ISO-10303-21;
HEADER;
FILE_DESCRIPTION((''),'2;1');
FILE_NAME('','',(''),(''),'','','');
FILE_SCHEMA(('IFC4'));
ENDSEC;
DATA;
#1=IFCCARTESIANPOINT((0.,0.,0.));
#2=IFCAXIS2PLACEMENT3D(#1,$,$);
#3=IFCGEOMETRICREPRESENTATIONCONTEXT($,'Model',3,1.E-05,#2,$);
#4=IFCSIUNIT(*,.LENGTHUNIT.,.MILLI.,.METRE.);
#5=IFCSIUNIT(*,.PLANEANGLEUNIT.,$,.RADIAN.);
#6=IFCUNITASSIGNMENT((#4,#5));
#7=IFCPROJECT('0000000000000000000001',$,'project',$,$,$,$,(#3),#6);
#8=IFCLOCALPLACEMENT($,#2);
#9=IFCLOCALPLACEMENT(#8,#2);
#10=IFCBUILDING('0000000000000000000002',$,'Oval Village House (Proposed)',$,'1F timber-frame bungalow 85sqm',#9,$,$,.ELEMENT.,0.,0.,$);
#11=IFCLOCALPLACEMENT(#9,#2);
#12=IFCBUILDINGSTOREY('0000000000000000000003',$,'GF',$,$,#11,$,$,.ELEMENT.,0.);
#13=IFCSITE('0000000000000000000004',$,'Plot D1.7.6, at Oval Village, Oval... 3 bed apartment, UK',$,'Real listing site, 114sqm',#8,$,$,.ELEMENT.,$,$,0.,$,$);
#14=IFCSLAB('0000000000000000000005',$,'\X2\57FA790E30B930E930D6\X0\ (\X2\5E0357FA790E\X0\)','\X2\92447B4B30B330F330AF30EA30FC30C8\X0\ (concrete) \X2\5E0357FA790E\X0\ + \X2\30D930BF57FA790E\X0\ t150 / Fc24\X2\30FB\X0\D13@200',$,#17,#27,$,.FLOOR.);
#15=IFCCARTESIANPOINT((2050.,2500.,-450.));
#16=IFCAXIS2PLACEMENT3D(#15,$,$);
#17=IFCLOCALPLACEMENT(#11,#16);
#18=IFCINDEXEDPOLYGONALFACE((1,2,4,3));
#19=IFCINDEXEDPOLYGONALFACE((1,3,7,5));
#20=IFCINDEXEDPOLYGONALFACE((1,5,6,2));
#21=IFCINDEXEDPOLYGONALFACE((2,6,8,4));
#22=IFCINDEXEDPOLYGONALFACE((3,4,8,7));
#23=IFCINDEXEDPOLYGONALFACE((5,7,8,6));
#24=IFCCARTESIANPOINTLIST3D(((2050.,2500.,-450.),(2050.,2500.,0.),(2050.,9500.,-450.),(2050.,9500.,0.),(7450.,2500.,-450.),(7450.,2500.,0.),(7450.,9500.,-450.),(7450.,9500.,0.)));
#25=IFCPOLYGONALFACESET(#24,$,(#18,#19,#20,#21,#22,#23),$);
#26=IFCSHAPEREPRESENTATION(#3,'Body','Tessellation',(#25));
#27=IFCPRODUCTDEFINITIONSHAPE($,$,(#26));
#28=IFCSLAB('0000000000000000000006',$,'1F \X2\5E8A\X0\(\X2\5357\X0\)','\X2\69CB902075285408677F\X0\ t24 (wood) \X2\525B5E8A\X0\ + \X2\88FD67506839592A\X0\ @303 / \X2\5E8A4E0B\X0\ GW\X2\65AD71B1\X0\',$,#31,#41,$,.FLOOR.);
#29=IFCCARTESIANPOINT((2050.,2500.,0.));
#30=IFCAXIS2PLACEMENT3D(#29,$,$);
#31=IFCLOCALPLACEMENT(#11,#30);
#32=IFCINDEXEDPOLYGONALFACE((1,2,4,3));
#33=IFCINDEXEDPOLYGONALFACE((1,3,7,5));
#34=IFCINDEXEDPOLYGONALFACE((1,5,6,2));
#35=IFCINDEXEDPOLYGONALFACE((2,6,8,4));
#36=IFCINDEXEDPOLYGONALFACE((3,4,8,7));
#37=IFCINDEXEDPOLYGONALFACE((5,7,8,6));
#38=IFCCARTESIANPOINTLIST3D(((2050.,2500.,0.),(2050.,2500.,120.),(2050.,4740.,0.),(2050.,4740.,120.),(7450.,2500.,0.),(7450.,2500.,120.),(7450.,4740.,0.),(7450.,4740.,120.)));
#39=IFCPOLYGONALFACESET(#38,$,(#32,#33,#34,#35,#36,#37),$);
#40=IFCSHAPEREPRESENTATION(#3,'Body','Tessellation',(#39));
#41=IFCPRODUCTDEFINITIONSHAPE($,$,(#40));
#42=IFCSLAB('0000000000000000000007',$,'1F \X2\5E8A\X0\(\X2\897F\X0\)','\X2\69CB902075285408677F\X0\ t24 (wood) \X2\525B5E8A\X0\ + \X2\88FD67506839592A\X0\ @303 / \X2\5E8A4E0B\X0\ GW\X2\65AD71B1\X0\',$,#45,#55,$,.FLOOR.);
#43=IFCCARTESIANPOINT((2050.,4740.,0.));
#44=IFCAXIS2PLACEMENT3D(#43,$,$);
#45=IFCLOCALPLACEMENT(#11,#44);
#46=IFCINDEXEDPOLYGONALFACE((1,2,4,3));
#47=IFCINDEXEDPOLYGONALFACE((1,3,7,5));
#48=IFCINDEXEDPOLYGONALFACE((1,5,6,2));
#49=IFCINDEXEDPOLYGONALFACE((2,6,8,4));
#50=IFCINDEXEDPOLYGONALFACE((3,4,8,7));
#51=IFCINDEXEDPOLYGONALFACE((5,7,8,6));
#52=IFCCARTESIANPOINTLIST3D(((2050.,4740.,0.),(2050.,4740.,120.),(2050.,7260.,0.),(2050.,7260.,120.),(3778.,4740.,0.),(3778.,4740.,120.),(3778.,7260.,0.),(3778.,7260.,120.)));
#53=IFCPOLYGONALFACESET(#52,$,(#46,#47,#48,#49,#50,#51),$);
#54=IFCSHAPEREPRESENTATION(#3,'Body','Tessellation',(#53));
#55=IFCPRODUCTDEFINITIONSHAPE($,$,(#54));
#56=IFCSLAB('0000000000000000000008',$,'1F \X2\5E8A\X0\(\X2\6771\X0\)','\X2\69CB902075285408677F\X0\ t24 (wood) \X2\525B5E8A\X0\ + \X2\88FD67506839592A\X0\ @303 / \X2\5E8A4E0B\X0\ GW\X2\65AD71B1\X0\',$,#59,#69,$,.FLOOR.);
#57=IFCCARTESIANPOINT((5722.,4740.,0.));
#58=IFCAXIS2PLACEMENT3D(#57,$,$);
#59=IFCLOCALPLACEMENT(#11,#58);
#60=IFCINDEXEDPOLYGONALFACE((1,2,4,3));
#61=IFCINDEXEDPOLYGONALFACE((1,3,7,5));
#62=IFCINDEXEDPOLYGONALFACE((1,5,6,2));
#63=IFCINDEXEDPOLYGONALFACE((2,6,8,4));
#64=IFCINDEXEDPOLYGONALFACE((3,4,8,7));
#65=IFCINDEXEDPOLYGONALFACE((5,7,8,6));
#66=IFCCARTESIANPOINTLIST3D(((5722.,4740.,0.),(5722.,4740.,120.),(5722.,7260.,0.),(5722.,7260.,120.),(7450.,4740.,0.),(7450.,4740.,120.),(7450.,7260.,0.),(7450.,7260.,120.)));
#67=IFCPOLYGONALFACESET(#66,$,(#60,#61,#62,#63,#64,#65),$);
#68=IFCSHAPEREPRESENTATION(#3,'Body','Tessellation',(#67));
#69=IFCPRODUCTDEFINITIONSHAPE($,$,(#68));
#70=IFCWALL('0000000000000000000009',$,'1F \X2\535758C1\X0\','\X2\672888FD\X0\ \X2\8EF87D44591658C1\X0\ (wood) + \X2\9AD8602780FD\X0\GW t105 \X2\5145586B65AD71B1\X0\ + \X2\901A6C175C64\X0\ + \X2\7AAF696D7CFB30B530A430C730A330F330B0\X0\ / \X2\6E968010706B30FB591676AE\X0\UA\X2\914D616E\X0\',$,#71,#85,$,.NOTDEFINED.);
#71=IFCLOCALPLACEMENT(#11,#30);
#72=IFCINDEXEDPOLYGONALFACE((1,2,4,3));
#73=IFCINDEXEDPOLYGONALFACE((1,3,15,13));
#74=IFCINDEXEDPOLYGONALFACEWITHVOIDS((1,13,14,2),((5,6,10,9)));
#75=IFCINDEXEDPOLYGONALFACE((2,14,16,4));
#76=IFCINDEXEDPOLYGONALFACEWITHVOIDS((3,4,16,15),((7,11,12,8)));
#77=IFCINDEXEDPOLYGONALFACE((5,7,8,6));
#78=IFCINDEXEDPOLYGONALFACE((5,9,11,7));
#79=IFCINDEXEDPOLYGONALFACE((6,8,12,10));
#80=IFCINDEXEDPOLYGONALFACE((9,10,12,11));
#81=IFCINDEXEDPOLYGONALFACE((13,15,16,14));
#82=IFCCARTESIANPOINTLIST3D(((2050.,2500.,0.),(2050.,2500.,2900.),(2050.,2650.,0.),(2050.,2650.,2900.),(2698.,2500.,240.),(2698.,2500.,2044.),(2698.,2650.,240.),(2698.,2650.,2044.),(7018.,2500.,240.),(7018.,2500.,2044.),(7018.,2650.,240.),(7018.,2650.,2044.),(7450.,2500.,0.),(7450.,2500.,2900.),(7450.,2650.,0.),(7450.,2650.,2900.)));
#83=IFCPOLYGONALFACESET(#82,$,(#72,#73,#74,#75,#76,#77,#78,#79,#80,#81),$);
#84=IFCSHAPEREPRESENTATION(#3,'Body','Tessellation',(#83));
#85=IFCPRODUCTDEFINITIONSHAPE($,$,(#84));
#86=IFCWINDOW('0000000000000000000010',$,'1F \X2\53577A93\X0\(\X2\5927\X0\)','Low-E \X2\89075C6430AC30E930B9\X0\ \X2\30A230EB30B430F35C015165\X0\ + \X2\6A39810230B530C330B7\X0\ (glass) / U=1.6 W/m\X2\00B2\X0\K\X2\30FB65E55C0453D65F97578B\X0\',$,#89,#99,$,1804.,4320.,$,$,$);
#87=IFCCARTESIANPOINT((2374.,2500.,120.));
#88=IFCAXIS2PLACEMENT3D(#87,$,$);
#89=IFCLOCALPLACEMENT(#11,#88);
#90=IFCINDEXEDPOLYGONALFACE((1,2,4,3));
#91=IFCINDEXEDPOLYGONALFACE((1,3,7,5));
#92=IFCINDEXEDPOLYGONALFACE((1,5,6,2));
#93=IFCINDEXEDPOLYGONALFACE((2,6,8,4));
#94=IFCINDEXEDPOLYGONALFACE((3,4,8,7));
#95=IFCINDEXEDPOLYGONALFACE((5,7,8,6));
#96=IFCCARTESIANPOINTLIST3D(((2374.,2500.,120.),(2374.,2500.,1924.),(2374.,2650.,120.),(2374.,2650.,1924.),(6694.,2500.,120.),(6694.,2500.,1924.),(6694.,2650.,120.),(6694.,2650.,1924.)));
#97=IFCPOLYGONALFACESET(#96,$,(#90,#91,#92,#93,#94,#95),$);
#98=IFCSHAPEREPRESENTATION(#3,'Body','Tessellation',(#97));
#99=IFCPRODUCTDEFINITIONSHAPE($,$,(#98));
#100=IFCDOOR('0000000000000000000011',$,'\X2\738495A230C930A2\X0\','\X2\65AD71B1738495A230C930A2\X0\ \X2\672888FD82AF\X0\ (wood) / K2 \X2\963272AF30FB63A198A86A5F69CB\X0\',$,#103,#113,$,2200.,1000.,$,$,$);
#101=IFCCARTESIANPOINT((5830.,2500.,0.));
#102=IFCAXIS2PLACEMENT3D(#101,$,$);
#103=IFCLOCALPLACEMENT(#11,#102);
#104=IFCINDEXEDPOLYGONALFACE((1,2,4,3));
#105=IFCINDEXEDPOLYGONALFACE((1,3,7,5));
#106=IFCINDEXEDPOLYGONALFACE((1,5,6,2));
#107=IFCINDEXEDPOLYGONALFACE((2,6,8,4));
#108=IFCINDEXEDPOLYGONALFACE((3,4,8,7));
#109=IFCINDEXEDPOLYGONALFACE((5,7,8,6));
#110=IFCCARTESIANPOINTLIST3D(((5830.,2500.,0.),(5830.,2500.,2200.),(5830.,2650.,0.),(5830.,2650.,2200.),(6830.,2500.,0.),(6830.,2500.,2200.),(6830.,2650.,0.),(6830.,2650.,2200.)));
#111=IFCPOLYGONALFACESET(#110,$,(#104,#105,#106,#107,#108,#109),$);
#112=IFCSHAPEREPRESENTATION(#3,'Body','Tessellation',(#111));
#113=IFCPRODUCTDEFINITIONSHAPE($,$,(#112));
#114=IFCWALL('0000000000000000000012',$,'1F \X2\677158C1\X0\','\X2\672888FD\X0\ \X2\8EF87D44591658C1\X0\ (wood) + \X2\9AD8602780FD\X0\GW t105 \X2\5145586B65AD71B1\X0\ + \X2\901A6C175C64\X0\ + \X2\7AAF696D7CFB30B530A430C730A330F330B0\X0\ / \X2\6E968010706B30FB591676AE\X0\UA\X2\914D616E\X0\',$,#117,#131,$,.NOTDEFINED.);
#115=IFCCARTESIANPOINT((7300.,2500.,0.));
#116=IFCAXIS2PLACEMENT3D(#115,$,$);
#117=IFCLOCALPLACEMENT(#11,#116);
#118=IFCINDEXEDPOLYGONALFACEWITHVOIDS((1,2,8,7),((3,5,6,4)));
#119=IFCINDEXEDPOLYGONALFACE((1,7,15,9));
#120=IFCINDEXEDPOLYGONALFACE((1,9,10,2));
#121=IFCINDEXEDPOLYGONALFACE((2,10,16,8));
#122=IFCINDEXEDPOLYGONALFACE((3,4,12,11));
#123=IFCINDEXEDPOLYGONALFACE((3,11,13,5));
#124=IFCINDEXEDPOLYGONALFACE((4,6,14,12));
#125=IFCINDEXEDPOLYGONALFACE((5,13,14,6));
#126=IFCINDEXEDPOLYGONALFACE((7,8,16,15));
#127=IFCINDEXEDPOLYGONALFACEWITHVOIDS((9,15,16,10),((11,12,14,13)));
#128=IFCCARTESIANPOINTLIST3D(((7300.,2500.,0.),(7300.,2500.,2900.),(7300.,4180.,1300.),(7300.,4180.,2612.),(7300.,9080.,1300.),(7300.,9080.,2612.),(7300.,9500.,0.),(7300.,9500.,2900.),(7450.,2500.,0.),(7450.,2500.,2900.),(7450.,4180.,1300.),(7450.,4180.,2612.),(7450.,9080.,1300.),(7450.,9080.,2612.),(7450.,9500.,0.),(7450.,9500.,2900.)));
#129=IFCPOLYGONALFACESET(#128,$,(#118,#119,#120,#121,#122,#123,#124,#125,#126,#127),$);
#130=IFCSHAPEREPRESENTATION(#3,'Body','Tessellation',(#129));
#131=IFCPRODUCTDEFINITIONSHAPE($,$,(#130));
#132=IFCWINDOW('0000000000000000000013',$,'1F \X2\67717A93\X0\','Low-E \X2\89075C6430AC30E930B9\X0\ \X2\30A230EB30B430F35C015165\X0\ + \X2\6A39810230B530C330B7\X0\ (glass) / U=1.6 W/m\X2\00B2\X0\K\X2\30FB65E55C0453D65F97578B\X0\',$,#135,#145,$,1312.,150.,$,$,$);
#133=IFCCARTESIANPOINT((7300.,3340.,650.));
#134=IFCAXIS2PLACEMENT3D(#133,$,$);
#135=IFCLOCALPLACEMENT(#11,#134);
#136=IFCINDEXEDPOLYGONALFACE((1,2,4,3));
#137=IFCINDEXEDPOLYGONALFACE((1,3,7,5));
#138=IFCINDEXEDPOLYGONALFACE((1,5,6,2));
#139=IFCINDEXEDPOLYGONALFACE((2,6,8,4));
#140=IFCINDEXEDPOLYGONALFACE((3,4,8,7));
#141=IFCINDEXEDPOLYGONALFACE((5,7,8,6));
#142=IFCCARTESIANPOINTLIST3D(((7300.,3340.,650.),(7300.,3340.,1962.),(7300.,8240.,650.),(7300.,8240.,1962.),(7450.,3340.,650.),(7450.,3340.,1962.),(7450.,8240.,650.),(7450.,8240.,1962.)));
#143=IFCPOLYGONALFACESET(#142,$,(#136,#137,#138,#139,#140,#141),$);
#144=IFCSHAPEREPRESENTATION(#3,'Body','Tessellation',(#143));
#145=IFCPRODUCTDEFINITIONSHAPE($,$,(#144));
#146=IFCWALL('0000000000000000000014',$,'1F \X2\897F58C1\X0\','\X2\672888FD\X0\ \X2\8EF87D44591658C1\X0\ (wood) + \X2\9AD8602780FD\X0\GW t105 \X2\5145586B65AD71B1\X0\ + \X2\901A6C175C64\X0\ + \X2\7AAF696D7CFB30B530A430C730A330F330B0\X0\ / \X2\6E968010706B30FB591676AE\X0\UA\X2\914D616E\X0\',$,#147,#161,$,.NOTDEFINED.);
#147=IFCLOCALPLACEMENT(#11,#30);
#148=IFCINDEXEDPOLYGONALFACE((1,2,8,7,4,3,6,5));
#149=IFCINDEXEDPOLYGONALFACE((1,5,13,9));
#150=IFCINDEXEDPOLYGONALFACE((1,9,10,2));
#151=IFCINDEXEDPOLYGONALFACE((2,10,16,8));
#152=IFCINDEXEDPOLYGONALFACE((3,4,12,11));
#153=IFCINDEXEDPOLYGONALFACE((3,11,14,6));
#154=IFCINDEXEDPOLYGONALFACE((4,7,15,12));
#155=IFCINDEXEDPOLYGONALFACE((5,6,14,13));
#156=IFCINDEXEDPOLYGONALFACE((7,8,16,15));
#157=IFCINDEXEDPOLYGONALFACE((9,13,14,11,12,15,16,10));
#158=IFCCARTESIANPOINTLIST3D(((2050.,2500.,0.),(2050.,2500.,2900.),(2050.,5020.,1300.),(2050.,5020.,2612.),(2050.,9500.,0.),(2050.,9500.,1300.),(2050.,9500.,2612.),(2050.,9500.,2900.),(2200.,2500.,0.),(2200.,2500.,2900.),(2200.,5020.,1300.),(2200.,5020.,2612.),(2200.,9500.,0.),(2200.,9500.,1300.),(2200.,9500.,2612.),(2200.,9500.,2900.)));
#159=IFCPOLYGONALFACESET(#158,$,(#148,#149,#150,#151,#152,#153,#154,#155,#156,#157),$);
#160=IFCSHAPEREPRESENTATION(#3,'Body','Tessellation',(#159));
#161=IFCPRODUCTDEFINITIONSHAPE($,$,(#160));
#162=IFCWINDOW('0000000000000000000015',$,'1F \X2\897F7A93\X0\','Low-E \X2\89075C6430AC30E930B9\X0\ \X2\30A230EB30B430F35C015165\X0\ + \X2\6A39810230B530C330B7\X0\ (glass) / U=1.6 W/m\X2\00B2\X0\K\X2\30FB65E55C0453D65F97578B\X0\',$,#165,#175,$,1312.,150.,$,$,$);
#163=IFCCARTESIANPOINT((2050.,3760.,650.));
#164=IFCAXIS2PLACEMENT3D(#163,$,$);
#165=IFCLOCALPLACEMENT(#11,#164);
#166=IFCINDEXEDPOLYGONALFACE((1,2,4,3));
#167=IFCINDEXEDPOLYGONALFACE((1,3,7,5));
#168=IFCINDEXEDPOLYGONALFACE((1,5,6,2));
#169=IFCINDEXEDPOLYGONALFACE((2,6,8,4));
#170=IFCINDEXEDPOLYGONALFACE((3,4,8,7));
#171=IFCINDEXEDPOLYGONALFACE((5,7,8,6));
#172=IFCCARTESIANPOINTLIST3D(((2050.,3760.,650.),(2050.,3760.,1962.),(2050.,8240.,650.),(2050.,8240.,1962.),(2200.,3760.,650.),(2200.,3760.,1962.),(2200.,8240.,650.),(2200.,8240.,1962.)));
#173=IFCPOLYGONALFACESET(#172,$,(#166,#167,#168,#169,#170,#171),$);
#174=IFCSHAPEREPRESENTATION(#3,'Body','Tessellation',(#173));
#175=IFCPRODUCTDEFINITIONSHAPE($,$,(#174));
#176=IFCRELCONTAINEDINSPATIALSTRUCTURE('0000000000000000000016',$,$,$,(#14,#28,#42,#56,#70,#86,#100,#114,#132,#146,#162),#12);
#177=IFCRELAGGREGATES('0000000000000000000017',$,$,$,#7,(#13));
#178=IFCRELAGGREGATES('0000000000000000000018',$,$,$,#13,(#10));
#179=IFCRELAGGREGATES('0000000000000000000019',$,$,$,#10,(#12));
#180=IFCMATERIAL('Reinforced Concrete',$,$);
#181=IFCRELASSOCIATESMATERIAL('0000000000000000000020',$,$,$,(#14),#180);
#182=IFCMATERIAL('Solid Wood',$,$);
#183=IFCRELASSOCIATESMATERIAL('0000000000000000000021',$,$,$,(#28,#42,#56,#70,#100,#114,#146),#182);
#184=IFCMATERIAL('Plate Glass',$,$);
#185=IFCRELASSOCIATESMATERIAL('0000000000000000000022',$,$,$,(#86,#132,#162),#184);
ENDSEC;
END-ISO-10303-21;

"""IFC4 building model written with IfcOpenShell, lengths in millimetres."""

from ifc_helpers import new_model, si_unit, frame, frame_2d, origin, place, context, project, spatial, rectangle, extrude, material, element, fill, save


model = new_model("IFC4")

# Units and contexts
model_context = context("Model", 3, precision=1e-05, world=origin())
ifc_project = project(units=[si_unit("LENGTHUNIT", "METRE", prefix="MILLI"), si_unit("PLANEANGLEUNIT", "RADIAN")], contexts=[model_context])

# Site, building, storey
site_placement = place(None, origin())
site = spatial("IfcSite", under=ifc_project, at=site_placement, Name="Plot D1.7.6, at Oval Village, Oval... 3 bed apartment, UK", ObjectType="Real listing site, 114sqm", CompositionType="ELEMENT", RefElevation=0.0)
building_placement = place(site_placement, origin())
building = spatial("IfcBuilding", under=site, at=building_placement, Name="Oval Village House (Proposed)", ObjectType="1F timber-frame bungalow 85sqm", CompositionType="ELEMENT", ElevationOfRefHeight=0.0, ElevationOfTerrain=0.0)
storey_placement = place(building_placement, origin())
storey = spatial("IfcBuildingStorey", under=building, at=storey_placement, Name="GF", CompositionType="ELEMENT", Elevation=0.0)

# Slabs
ifc_material_1 = material(Name="Reinforced Concrete")
slab_1_placement = place(storey_placement, frame((2050.0, 2500.0, -450.0)))
element("IfcSlab", 1, at=slab_1_placement, inside=storey, material=ifc_material_1, Name="基礎スラブ (布基礎)", Description="鉄筋コンクリート (concrete) 布基礎 + ベタ基礎 t150 / Fc24・D13@200", PredefinedType="FLOOR", context=model_context, shape_type="SweptSolid", body=[
    extrude(rectangle(XDim=5400.0, YDim=7000.0, at=frame_2d((2700.0, 3500.0))), frame((2050.0, 2500.0, -450.0)), (0.0, 0.0, 1.0), 450.0),
])
ifc_material_2 = material(Name="Solid Wood")
slab_2_placement = place(storey_placement, frame((2050.0, 2500.0, 0.0)))
element("IfcSlab", 2, at=slab_2_placement, inside=storey, material=ifc_material_2, Name="1F 床(南)", Description="構造用合板 t24 (wood) 剛床 + 製材根太 @303 / 床下 GW断熱", PredefinedType="FLOOR", context=model_context, shape_type="SweptSolid", body=[
    extrude(rectangle(XDim=5400.0, YDim=2240.0, at=frame_2d((2700.0, 1120.0))), frame((2050.0, 2500.0, 0.0)), (0.0, 0.0, 1.0), 120.0),
])
slab_3_placement = place(storey_placement, frame((2050.0, 4740.0, 0.0)))
element("IfcSlab", 3, at=slab_3_placement, inside=storey, material=ifc_material_2, Name="1F 床(西)", Description="構造用合板 t24 (wood) 剛床 + 製材根太 @303 / 床下 GW断熱", PredefinedType="FLOOR", context=model_context, shape_type="SweptSolid", body=[
    extrude(rectangle(XDim=1728.0, YDim=2520.0, at=frame_2d((864.0, 1260.0))), frame((2050.0, 4740.0, 0.0)), (0.0, 0.0, 1.0), 120.0),
])
slab_4_placement = place(storey_placement, frame((5722.0, 4740.0, 0.0)))
element("IfcSlab", 4, at=slab_4_placement, inside=storey, material=ifc_material_2, Name="1F 床(東)", Description="構造用合板 t24 (wood) 剛床 + 製材根太 @303 / 床下 GW断熱", PredefinedType="FLOOR", context=model_context, shape_type="SweptSolid", body=[
    extrude(rectangle(XDim=1728.0, YDim=2520.0, at=frame_2d((864.0, 1260.0))), frame((5722.0, 4740.0, 0.0)), (0.0, 0.0, 1.0), 120.0),
])

# Wall, openings, window, door
wall_1_placement = place(storey_placement, frame((2050.0, 2500.0, 0.0)))
wall_1 = element("IfcWall", 5, at=wall_1_placement, inside=storey, material=ifc_material_2, Name="1F 南壁", Description="木製 軸組外壁 (wood) + 高性能GW t105 充填断熱 + 通気層 + 窯業系サイディング / 準耐火・外皮UA配慮", PredefinedType="NOTDEFINED", context=model_context, shape_type="SweptSolid", body=[
    extrude(rectangle(XDim=5400.0, YDim=150.0, at=frame_2d((2700.0, 75.0))), frame((2050.0, 2500.0, 0.0)), (0.0, 0.0, 1.0), 2900.0),
])
opening_1_placement = place(storey_placement, frame((2374.0, 2500.0, 120.0)))
opening_1 = element("IfcOpeningElement", 6, at=opening_1_placement, cuts=wall_1, PredefinedType="NOTDEFINED", context=model_context, shape_type="SweptSolid", body=[
    extrude(rectangle(XDim=4320.0, YDim=150.0, at=frame_2d((2160.0, 75.0))), frame((2374.0, 2500.0, 120.0)), (0.0, 0.0, 1.0), 1804.0),
])
opening_2_placement = place(storey_placement, frame((5830.0, 2500.0, 0.0)))
opening_2 = element("IfcOpeningElement", 7, at=opening_2_placement, cuts=wall_1, PredefinedType="NOTDEFINED", context=model_context, shape_type="SweptSolid", body=[
    extrude(rectangle(XDim=1000.0, YDim=150.0, at=frame_2d((500.0, 75.0))), frame((5830.0, 2500.0, 0.0)), (0.0, 0.0, 1.0), 2200.0),
])
ifc_material_3 = material(Name="Plate Glass")
window_1_placement = place(storey_placement, frame((2374.0, 2500.0, 120.0)))
window_1 = element("IfcWindow", 8, at=window_1_placement, inside=storey, material=ifc_material_3, Name="1F 南窓(大)", Description="Low-E 複層ガラス アルゴン封入 + 樹脂サッシ (glass) / U=1.6 W/m²K・日射取得型", OverallHeight=1804.0, OverallWidth=4320.0, context=model_context, shape_type="SweptSolid", body=[
    extrude(rectangle(XDim=4320.0, YDim=150.0, at=frame_2d((2160.0, 75.0))), frame((2374.0, 2500.0, 120.0)), (0.0, 0.0, 1.0), 1804.0),
])
fill(opening_1, window_1)
door_placement = place(storey_placement, frame((5830.0, 2500.0, 0.0)))
door = element("IfcDoor", 9, at=door_placement, inside=storey, material=ifc_material_2, Name="玄関ドア", Description="断熱玄関ドア 木製芯 (wood) / K2 防犯・採風機構", OverallHeight=2200.0, OverallWidth=1000.0, context=model_context, shape_type="SweptSolid", body=[
    extrude(rectangle(XDim=1000.0, YDim=150.0, at=frame_2d((500.0, 75.0))), frame((5830.0, 2500.0, 0.0)), (0.0, 0.0, 1.0), 2200.0),
])
fill(opening_2, door)

# Walls, openings, windows
wall_2_placement = place(storey_placement, frame((7300.0, 2500.0, 0.0)))
wall_2 = element("IfcWall", 10, at=wall_2_placement, inside=storey, material=ifc_material_2, Name="1F 東壁", Description="木製 軸組外壁 (wood) + 高性能GW t105 充填断熱 + 通気層 + 窯業系サイディング / 準耐火・外皮UA配慮", PredefinedType="NOTDEFINED", context=model_context, shape_type="SweptSolid", body=[
    extrude(rectangle(XDim=150.0, YDim=7000.0, at=frame_2d((75.0, 3500.0))), frame((7300.0, 2500.0, 0.0)), (0.0, 0.0, 1.0), 2900.0),
])
opening_3_placement = place(storey_placement, frame((7300.0, 3340.0, 650.0)))
opening_3 = element("IfcOpeningElement", 11, at=opening_3_placement, cuts=wall_2, PredefinedType="NOTDEFINED", context=model_context, shape_type="SweptSolid", body=[
    extrude(rectangle(XDim=150.0, YDim=4900.0, at=frame_2d((75.0, 2450.0))), frame((7300.0, 3340.0, 650.0)), (0.0, 0.0, 1.0), 1312.0),
])
window_2_placement = place(storey_placement, frame((7300.0, 3340.0, 650.0)))
window_2 = element("IfcWindow", 12, at=window_2_placement, inside=storey, material=ifc_material_3, Name="1F 東窓", Description="Low-E 複層ガラス アルゴン封入 + 樹脂サッシ (glass) / U=1.6 W/m²K・日射取得型", OverallHeight=1312.0, OverallWidth=150.0, context=model_context, shape_type="SweptSolid", body=[
    extrude(rectangle(XDim=150.0, YDim=4900.0, at=frame_2d((75.0, 2450.0))), frame((7300.0, 3340.0, 650.0)), (0.0, 0.0, 1.0), 1312.0),
])
fill(opening_3, window_2)
wall_3_placement = place(storey_placement, frame((2050.0, 2500.0, 0.0)))
wall_3 = element("IfcWall", 13, at=wall_3_placement, inside=storey, material=ifc_material_2, Name="1F 西壁", Description="木製 軸組外壁 (wood) + 高性能GW t105 充填断熱 + 通気層 + 窯業系サイディング / 準耐火・外皮UA配慮", PredefinedType="NOTDEFINED", context=model_context, shape_type="SweptSolid", body=[
    extrude(rectangle(XDim=150.0, YDim=7000.0, at=frame_2d((75.0, 3500.0))), frame((2050.0, 2500.0, 0.0)), (0.0, 0.0, 1.0), 2900.0),
])
opening_4_placement = place(storey_placement, frame((2050.0, 3760.0, 650.0)))
opening_4 = element("IfcOpeningElement", 14, at=opening_4_placement, cuts=wall_3, PredefinedType="NOTDEFINED", context=model_context, shape_type="SweptSolid", body=[
    extrude(rectangle(XDim=150.0, YDim=4480.0, at=frame_2d((75.0, 2240.0))), frame((2050.0, 3760.0, 650.0)), (0.0, 0.0, 1.0), 1312.0),
])
window_3_placement = place(storey_placement, frame((2050.0, 3760.0, 650.0)))
window_3 = element("IfcWindow", 15, at=window_3_placement, inside=storey, material=ifc_material_3, Name="1F 西窓", Description="Low-E 複層ガラス アルゴン封入 + 樹脂サッシ (glass) / U=1.6 W/m²K・日射取得型", OverallHeight=1312.0, OverallWidth=150.0, context=model_context, shape_type="SweptSolid", body=[
    extrude(rectangle(XDim=150.0, YDim=4480.0, at=frame_2d((75.0, 2240.0))), frame((2050.0, 3760.0, 650.0)), (0.0, 0.0, 1.0), 1312.0),
])
fill(opening_4, window_3)

save(model, "model.ifc")
